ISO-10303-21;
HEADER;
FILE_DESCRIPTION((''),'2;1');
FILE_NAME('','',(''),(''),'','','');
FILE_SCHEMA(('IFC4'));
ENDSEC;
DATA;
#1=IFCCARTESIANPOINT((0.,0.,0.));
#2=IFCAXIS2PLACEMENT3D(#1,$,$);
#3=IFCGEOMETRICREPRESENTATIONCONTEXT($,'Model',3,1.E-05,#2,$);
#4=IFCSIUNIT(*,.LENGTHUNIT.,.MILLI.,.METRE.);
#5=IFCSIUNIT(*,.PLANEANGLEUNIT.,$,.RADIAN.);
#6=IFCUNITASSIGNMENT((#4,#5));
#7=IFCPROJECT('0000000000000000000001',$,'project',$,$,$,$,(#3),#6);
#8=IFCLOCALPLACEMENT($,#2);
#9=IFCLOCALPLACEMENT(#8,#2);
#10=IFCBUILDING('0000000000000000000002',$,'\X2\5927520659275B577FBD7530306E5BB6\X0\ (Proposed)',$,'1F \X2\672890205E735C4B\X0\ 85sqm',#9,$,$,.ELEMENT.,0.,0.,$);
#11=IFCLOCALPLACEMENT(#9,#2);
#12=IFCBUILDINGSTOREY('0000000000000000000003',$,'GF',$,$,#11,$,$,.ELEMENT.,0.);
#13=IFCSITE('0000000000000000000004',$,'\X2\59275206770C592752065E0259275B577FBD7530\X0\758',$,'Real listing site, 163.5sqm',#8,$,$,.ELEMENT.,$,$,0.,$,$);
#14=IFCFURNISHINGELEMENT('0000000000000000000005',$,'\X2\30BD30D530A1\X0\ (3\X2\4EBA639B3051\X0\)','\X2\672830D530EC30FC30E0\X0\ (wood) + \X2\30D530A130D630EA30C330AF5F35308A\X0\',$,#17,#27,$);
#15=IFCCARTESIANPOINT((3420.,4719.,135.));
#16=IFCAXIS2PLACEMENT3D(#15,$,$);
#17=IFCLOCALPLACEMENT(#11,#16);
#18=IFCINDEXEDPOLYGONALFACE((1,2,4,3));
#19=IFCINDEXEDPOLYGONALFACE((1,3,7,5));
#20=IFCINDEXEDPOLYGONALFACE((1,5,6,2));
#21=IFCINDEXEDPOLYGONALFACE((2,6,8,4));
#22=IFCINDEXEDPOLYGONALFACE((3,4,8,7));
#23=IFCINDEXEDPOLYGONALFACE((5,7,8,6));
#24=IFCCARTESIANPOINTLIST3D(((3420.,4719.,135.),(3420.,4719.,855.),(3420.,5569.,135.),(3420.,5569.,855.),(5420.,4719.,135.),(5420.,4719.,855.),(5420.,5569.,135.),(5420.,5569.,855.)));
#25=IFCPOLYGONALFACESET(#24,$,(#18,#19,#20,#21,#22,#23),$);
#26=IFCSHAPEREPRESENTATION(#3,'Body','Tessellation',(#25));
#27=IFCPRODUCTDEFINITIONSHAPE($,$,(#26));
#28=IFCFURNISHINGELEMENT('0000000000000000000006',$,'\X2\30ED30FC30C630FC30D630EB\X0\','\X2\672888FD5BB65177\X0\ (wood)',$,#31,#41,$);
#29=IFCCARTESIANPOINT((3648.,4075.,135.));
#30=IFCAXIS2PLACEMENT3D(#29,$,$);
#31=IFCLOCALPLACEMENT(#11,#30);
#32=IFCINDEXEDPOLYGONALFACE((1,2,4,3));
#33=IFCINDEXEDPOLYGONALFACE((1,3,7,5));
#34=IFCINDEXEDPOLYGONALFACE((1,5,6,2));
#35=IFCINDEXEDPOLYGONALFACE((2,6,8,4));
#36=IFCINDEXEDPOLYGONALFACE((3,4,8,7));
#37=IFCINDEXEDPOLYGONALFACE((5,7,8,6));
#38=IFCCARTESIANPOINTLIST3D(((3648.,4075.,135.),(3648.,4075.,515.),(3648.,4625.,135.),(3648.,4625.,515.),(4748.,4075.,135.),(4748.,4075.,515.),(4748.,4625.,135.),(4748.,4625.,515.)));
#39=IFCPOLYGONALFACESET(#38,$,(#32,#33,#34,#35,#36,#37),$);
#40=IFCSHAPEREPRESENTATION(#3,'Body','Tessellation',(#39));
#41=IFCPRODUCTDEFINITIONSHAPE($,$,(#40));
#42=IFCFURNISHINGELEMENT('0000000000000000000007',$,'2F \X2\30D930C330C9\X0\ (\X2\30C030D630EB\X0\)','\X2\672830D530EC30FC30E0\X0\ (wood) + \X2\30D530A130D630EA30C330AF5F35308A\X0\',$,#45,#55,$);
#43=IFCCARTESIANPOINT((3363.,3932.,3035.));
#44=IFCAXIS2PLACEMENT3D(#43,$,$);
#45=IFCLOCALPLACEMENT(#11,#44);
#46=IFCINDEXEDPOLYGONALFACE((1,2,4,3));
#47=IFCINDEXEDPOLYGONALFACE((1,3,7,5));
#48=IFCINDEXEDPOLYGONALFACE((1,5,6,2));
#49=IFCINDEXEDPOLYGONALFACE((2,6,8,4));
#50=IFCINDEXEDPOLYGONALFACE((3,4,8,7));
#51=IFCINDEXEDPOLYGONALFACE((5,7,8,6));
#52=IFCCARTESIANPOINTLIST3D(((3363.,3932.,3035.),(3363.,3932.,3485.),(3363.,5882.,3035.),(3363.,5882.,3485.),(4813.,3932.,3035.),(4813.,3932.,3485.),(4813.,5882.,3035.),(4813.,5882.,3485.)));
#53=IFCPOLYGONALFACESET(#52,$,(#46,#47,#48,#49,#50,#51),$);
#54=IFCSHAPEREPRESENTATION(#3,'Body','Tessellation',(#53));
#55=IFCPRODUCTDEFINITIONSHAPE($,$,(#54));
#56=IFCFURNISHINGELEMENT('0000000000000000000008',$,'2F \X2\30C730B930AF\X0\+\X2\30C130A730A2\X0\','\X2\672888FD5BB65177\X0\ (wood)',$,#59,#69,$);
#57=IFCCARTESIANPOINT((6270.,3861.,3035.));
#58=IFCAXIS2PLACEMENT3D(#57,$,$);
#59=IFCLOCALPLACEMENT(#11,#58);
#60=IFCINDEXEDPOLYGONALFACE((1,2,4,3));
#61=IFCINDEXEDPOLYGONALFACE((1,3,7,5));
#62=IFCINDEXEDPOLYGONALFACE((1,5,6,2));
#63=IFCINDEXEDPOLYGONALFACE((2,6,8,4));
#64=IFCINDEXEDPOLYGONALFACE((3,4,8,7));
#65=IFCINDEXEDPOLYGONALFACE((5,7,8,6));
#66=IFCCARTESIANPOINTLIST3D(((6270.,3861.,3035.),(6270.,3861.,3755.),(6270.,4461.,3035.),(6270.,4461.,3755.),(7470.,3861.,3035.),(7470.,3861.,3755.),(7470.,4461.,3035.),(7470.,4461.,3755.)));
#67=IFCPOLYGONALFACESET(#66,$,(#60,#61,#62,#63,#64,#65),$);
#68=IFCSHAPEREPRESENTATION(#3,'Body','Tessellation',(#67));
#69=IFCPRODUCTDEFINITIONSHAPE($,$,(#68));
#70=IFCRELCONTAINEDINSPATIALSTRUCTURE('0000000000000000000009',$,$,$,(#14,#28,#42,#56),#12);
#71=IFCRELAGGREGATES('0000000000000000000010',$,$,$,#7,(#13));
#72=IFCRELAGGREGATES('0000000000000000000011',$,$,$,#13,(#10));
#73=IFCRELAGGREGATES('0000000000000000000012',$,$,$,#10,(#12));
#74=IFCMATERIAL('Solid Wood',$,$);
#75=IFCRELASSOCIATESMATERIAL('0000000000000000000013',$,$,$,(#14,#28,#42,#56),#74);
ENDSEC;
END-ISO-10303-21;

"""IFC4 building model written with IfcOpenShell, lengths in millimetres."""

from ifc_helpers import new_model, si_unit, frame, frame_2d, origin, place, context, project, spatial, rectangle, extrude, material, element, save


model = new_model("IFC4")

# Units and contexts
model_context = context("Model", 3, precision=1e-05, world=origin())
ifc_project = project(units=[si_unit("LENGTHUNIT", "METRE", prefix="MILLI"), si_unit("PLANEANGLEUNIT", "RADIAN")], contexts=[model_context])

# Site, building, storey
site_placement = place(None, origin())
site = spatial("IfcSite", under=ifc_project, at=site_placement, Name="大分県大分市大字羽田758", ObjectType="Real listing site, 163.5sqm", CompositionType="ELEMENT", RefElevation=0.0)
building_placement = place(site_placement, origin())
building = spatial("IfcBuilding", under=site, at=building_placement, Name="大分大字羽田の家 (Proposed)", ObjectType="1F 木造平屋 85sqm", CompositionType="ELEMENT", ElevationOfRefHeight=0.0, ElevationOfTerrain=0.0)
storey_placement = place(building_placement, origin())
storey = spatial("IfcBuildingStorey", under=building, at=storey_placement, Name="GF", CompositionType="ELEMENT", Elevation=0.0)

# Shared definitions
ifc_material_1 = material(Name="Solid Wood")

# Furnishing elements
furnishing_1_placement = place(storey_placement, frame((3420.0, 4719.0, 135.0)))
element("IfcFurnishingElement", 1, at=furnishing_1_placement, inside=storey, material=ifc_material_1, Name="ソファ (3人掛け)", Description="木フレーム (wood) + ファブリック張り", context=model_context, shape_type="SweptSolid", body=[
    extrude(rectangle(XDim=2000.0, YDim=850.0, at=frame_2d((1000.0, 425.0))), frame((3420.0, 4719.0, 135.0)), (0.0, 0.0, 1.0), 720.0),
])
furnishing_2_placement = place(storey_placement, frame((3648.0, 4075.0, 135.0)))
element("IfcFurnishingElement", 2, at=furnishing_2_placement, inside=storey, material=ifc_material_1, Name="ローテーブル", Description="木製家具 (wood)", context=model_context, shape_type="SweptSolid", body=[
    extrude(rectangle(XDim=1100.0, YDim=550.0, at=frame_2d((550.0, 275.0))), frame((3648.0, 4075.0, 135.0)), (0.0, 0.0, 1.0), 380.0),
])
furnishing_3_placement = place(storey_placement, frame((3363.0, 3932.0, 3035.0)))
element("IfcFurnishingElement", 3, at=furnishing_3_placement, inside=storey, material=ifc_material_1, Name="2F ベッド (ダブル)", Description="木フレーム (wood) + ファブリック張り", context=model_context, shape_type="SweptSolid", body=[
    extrude(rectangle(XDim=1450.0, YDim=1950.0, at=frame_2d((725.0, 975.0))), frame((3363.0, 3932.0, 3035.0)), (0.0, 0.0, 1.0), 450.0),
])
furnishing_4_placement = place(storey_placement, frame((6270.0, 3861.0, 3035.0)))
element("IfcFurnishingElement", 4, at=furnishing_4_placement, inside=storey, material=ifc_material_1, Name="2F デスク+チェア", Description="木製家具 (wood)", context=model_context, shape_type="SweptSolid", body=[
    extrude(rectangle(XDim=1200.0, YDim=600.0, at=frame_2d((600.0, 300.0))), frame((6270.0, 3861.0, 3035.0)), (0.0, 0.0, 1.0), 720.0),
])

save(model, "model.ifc")
